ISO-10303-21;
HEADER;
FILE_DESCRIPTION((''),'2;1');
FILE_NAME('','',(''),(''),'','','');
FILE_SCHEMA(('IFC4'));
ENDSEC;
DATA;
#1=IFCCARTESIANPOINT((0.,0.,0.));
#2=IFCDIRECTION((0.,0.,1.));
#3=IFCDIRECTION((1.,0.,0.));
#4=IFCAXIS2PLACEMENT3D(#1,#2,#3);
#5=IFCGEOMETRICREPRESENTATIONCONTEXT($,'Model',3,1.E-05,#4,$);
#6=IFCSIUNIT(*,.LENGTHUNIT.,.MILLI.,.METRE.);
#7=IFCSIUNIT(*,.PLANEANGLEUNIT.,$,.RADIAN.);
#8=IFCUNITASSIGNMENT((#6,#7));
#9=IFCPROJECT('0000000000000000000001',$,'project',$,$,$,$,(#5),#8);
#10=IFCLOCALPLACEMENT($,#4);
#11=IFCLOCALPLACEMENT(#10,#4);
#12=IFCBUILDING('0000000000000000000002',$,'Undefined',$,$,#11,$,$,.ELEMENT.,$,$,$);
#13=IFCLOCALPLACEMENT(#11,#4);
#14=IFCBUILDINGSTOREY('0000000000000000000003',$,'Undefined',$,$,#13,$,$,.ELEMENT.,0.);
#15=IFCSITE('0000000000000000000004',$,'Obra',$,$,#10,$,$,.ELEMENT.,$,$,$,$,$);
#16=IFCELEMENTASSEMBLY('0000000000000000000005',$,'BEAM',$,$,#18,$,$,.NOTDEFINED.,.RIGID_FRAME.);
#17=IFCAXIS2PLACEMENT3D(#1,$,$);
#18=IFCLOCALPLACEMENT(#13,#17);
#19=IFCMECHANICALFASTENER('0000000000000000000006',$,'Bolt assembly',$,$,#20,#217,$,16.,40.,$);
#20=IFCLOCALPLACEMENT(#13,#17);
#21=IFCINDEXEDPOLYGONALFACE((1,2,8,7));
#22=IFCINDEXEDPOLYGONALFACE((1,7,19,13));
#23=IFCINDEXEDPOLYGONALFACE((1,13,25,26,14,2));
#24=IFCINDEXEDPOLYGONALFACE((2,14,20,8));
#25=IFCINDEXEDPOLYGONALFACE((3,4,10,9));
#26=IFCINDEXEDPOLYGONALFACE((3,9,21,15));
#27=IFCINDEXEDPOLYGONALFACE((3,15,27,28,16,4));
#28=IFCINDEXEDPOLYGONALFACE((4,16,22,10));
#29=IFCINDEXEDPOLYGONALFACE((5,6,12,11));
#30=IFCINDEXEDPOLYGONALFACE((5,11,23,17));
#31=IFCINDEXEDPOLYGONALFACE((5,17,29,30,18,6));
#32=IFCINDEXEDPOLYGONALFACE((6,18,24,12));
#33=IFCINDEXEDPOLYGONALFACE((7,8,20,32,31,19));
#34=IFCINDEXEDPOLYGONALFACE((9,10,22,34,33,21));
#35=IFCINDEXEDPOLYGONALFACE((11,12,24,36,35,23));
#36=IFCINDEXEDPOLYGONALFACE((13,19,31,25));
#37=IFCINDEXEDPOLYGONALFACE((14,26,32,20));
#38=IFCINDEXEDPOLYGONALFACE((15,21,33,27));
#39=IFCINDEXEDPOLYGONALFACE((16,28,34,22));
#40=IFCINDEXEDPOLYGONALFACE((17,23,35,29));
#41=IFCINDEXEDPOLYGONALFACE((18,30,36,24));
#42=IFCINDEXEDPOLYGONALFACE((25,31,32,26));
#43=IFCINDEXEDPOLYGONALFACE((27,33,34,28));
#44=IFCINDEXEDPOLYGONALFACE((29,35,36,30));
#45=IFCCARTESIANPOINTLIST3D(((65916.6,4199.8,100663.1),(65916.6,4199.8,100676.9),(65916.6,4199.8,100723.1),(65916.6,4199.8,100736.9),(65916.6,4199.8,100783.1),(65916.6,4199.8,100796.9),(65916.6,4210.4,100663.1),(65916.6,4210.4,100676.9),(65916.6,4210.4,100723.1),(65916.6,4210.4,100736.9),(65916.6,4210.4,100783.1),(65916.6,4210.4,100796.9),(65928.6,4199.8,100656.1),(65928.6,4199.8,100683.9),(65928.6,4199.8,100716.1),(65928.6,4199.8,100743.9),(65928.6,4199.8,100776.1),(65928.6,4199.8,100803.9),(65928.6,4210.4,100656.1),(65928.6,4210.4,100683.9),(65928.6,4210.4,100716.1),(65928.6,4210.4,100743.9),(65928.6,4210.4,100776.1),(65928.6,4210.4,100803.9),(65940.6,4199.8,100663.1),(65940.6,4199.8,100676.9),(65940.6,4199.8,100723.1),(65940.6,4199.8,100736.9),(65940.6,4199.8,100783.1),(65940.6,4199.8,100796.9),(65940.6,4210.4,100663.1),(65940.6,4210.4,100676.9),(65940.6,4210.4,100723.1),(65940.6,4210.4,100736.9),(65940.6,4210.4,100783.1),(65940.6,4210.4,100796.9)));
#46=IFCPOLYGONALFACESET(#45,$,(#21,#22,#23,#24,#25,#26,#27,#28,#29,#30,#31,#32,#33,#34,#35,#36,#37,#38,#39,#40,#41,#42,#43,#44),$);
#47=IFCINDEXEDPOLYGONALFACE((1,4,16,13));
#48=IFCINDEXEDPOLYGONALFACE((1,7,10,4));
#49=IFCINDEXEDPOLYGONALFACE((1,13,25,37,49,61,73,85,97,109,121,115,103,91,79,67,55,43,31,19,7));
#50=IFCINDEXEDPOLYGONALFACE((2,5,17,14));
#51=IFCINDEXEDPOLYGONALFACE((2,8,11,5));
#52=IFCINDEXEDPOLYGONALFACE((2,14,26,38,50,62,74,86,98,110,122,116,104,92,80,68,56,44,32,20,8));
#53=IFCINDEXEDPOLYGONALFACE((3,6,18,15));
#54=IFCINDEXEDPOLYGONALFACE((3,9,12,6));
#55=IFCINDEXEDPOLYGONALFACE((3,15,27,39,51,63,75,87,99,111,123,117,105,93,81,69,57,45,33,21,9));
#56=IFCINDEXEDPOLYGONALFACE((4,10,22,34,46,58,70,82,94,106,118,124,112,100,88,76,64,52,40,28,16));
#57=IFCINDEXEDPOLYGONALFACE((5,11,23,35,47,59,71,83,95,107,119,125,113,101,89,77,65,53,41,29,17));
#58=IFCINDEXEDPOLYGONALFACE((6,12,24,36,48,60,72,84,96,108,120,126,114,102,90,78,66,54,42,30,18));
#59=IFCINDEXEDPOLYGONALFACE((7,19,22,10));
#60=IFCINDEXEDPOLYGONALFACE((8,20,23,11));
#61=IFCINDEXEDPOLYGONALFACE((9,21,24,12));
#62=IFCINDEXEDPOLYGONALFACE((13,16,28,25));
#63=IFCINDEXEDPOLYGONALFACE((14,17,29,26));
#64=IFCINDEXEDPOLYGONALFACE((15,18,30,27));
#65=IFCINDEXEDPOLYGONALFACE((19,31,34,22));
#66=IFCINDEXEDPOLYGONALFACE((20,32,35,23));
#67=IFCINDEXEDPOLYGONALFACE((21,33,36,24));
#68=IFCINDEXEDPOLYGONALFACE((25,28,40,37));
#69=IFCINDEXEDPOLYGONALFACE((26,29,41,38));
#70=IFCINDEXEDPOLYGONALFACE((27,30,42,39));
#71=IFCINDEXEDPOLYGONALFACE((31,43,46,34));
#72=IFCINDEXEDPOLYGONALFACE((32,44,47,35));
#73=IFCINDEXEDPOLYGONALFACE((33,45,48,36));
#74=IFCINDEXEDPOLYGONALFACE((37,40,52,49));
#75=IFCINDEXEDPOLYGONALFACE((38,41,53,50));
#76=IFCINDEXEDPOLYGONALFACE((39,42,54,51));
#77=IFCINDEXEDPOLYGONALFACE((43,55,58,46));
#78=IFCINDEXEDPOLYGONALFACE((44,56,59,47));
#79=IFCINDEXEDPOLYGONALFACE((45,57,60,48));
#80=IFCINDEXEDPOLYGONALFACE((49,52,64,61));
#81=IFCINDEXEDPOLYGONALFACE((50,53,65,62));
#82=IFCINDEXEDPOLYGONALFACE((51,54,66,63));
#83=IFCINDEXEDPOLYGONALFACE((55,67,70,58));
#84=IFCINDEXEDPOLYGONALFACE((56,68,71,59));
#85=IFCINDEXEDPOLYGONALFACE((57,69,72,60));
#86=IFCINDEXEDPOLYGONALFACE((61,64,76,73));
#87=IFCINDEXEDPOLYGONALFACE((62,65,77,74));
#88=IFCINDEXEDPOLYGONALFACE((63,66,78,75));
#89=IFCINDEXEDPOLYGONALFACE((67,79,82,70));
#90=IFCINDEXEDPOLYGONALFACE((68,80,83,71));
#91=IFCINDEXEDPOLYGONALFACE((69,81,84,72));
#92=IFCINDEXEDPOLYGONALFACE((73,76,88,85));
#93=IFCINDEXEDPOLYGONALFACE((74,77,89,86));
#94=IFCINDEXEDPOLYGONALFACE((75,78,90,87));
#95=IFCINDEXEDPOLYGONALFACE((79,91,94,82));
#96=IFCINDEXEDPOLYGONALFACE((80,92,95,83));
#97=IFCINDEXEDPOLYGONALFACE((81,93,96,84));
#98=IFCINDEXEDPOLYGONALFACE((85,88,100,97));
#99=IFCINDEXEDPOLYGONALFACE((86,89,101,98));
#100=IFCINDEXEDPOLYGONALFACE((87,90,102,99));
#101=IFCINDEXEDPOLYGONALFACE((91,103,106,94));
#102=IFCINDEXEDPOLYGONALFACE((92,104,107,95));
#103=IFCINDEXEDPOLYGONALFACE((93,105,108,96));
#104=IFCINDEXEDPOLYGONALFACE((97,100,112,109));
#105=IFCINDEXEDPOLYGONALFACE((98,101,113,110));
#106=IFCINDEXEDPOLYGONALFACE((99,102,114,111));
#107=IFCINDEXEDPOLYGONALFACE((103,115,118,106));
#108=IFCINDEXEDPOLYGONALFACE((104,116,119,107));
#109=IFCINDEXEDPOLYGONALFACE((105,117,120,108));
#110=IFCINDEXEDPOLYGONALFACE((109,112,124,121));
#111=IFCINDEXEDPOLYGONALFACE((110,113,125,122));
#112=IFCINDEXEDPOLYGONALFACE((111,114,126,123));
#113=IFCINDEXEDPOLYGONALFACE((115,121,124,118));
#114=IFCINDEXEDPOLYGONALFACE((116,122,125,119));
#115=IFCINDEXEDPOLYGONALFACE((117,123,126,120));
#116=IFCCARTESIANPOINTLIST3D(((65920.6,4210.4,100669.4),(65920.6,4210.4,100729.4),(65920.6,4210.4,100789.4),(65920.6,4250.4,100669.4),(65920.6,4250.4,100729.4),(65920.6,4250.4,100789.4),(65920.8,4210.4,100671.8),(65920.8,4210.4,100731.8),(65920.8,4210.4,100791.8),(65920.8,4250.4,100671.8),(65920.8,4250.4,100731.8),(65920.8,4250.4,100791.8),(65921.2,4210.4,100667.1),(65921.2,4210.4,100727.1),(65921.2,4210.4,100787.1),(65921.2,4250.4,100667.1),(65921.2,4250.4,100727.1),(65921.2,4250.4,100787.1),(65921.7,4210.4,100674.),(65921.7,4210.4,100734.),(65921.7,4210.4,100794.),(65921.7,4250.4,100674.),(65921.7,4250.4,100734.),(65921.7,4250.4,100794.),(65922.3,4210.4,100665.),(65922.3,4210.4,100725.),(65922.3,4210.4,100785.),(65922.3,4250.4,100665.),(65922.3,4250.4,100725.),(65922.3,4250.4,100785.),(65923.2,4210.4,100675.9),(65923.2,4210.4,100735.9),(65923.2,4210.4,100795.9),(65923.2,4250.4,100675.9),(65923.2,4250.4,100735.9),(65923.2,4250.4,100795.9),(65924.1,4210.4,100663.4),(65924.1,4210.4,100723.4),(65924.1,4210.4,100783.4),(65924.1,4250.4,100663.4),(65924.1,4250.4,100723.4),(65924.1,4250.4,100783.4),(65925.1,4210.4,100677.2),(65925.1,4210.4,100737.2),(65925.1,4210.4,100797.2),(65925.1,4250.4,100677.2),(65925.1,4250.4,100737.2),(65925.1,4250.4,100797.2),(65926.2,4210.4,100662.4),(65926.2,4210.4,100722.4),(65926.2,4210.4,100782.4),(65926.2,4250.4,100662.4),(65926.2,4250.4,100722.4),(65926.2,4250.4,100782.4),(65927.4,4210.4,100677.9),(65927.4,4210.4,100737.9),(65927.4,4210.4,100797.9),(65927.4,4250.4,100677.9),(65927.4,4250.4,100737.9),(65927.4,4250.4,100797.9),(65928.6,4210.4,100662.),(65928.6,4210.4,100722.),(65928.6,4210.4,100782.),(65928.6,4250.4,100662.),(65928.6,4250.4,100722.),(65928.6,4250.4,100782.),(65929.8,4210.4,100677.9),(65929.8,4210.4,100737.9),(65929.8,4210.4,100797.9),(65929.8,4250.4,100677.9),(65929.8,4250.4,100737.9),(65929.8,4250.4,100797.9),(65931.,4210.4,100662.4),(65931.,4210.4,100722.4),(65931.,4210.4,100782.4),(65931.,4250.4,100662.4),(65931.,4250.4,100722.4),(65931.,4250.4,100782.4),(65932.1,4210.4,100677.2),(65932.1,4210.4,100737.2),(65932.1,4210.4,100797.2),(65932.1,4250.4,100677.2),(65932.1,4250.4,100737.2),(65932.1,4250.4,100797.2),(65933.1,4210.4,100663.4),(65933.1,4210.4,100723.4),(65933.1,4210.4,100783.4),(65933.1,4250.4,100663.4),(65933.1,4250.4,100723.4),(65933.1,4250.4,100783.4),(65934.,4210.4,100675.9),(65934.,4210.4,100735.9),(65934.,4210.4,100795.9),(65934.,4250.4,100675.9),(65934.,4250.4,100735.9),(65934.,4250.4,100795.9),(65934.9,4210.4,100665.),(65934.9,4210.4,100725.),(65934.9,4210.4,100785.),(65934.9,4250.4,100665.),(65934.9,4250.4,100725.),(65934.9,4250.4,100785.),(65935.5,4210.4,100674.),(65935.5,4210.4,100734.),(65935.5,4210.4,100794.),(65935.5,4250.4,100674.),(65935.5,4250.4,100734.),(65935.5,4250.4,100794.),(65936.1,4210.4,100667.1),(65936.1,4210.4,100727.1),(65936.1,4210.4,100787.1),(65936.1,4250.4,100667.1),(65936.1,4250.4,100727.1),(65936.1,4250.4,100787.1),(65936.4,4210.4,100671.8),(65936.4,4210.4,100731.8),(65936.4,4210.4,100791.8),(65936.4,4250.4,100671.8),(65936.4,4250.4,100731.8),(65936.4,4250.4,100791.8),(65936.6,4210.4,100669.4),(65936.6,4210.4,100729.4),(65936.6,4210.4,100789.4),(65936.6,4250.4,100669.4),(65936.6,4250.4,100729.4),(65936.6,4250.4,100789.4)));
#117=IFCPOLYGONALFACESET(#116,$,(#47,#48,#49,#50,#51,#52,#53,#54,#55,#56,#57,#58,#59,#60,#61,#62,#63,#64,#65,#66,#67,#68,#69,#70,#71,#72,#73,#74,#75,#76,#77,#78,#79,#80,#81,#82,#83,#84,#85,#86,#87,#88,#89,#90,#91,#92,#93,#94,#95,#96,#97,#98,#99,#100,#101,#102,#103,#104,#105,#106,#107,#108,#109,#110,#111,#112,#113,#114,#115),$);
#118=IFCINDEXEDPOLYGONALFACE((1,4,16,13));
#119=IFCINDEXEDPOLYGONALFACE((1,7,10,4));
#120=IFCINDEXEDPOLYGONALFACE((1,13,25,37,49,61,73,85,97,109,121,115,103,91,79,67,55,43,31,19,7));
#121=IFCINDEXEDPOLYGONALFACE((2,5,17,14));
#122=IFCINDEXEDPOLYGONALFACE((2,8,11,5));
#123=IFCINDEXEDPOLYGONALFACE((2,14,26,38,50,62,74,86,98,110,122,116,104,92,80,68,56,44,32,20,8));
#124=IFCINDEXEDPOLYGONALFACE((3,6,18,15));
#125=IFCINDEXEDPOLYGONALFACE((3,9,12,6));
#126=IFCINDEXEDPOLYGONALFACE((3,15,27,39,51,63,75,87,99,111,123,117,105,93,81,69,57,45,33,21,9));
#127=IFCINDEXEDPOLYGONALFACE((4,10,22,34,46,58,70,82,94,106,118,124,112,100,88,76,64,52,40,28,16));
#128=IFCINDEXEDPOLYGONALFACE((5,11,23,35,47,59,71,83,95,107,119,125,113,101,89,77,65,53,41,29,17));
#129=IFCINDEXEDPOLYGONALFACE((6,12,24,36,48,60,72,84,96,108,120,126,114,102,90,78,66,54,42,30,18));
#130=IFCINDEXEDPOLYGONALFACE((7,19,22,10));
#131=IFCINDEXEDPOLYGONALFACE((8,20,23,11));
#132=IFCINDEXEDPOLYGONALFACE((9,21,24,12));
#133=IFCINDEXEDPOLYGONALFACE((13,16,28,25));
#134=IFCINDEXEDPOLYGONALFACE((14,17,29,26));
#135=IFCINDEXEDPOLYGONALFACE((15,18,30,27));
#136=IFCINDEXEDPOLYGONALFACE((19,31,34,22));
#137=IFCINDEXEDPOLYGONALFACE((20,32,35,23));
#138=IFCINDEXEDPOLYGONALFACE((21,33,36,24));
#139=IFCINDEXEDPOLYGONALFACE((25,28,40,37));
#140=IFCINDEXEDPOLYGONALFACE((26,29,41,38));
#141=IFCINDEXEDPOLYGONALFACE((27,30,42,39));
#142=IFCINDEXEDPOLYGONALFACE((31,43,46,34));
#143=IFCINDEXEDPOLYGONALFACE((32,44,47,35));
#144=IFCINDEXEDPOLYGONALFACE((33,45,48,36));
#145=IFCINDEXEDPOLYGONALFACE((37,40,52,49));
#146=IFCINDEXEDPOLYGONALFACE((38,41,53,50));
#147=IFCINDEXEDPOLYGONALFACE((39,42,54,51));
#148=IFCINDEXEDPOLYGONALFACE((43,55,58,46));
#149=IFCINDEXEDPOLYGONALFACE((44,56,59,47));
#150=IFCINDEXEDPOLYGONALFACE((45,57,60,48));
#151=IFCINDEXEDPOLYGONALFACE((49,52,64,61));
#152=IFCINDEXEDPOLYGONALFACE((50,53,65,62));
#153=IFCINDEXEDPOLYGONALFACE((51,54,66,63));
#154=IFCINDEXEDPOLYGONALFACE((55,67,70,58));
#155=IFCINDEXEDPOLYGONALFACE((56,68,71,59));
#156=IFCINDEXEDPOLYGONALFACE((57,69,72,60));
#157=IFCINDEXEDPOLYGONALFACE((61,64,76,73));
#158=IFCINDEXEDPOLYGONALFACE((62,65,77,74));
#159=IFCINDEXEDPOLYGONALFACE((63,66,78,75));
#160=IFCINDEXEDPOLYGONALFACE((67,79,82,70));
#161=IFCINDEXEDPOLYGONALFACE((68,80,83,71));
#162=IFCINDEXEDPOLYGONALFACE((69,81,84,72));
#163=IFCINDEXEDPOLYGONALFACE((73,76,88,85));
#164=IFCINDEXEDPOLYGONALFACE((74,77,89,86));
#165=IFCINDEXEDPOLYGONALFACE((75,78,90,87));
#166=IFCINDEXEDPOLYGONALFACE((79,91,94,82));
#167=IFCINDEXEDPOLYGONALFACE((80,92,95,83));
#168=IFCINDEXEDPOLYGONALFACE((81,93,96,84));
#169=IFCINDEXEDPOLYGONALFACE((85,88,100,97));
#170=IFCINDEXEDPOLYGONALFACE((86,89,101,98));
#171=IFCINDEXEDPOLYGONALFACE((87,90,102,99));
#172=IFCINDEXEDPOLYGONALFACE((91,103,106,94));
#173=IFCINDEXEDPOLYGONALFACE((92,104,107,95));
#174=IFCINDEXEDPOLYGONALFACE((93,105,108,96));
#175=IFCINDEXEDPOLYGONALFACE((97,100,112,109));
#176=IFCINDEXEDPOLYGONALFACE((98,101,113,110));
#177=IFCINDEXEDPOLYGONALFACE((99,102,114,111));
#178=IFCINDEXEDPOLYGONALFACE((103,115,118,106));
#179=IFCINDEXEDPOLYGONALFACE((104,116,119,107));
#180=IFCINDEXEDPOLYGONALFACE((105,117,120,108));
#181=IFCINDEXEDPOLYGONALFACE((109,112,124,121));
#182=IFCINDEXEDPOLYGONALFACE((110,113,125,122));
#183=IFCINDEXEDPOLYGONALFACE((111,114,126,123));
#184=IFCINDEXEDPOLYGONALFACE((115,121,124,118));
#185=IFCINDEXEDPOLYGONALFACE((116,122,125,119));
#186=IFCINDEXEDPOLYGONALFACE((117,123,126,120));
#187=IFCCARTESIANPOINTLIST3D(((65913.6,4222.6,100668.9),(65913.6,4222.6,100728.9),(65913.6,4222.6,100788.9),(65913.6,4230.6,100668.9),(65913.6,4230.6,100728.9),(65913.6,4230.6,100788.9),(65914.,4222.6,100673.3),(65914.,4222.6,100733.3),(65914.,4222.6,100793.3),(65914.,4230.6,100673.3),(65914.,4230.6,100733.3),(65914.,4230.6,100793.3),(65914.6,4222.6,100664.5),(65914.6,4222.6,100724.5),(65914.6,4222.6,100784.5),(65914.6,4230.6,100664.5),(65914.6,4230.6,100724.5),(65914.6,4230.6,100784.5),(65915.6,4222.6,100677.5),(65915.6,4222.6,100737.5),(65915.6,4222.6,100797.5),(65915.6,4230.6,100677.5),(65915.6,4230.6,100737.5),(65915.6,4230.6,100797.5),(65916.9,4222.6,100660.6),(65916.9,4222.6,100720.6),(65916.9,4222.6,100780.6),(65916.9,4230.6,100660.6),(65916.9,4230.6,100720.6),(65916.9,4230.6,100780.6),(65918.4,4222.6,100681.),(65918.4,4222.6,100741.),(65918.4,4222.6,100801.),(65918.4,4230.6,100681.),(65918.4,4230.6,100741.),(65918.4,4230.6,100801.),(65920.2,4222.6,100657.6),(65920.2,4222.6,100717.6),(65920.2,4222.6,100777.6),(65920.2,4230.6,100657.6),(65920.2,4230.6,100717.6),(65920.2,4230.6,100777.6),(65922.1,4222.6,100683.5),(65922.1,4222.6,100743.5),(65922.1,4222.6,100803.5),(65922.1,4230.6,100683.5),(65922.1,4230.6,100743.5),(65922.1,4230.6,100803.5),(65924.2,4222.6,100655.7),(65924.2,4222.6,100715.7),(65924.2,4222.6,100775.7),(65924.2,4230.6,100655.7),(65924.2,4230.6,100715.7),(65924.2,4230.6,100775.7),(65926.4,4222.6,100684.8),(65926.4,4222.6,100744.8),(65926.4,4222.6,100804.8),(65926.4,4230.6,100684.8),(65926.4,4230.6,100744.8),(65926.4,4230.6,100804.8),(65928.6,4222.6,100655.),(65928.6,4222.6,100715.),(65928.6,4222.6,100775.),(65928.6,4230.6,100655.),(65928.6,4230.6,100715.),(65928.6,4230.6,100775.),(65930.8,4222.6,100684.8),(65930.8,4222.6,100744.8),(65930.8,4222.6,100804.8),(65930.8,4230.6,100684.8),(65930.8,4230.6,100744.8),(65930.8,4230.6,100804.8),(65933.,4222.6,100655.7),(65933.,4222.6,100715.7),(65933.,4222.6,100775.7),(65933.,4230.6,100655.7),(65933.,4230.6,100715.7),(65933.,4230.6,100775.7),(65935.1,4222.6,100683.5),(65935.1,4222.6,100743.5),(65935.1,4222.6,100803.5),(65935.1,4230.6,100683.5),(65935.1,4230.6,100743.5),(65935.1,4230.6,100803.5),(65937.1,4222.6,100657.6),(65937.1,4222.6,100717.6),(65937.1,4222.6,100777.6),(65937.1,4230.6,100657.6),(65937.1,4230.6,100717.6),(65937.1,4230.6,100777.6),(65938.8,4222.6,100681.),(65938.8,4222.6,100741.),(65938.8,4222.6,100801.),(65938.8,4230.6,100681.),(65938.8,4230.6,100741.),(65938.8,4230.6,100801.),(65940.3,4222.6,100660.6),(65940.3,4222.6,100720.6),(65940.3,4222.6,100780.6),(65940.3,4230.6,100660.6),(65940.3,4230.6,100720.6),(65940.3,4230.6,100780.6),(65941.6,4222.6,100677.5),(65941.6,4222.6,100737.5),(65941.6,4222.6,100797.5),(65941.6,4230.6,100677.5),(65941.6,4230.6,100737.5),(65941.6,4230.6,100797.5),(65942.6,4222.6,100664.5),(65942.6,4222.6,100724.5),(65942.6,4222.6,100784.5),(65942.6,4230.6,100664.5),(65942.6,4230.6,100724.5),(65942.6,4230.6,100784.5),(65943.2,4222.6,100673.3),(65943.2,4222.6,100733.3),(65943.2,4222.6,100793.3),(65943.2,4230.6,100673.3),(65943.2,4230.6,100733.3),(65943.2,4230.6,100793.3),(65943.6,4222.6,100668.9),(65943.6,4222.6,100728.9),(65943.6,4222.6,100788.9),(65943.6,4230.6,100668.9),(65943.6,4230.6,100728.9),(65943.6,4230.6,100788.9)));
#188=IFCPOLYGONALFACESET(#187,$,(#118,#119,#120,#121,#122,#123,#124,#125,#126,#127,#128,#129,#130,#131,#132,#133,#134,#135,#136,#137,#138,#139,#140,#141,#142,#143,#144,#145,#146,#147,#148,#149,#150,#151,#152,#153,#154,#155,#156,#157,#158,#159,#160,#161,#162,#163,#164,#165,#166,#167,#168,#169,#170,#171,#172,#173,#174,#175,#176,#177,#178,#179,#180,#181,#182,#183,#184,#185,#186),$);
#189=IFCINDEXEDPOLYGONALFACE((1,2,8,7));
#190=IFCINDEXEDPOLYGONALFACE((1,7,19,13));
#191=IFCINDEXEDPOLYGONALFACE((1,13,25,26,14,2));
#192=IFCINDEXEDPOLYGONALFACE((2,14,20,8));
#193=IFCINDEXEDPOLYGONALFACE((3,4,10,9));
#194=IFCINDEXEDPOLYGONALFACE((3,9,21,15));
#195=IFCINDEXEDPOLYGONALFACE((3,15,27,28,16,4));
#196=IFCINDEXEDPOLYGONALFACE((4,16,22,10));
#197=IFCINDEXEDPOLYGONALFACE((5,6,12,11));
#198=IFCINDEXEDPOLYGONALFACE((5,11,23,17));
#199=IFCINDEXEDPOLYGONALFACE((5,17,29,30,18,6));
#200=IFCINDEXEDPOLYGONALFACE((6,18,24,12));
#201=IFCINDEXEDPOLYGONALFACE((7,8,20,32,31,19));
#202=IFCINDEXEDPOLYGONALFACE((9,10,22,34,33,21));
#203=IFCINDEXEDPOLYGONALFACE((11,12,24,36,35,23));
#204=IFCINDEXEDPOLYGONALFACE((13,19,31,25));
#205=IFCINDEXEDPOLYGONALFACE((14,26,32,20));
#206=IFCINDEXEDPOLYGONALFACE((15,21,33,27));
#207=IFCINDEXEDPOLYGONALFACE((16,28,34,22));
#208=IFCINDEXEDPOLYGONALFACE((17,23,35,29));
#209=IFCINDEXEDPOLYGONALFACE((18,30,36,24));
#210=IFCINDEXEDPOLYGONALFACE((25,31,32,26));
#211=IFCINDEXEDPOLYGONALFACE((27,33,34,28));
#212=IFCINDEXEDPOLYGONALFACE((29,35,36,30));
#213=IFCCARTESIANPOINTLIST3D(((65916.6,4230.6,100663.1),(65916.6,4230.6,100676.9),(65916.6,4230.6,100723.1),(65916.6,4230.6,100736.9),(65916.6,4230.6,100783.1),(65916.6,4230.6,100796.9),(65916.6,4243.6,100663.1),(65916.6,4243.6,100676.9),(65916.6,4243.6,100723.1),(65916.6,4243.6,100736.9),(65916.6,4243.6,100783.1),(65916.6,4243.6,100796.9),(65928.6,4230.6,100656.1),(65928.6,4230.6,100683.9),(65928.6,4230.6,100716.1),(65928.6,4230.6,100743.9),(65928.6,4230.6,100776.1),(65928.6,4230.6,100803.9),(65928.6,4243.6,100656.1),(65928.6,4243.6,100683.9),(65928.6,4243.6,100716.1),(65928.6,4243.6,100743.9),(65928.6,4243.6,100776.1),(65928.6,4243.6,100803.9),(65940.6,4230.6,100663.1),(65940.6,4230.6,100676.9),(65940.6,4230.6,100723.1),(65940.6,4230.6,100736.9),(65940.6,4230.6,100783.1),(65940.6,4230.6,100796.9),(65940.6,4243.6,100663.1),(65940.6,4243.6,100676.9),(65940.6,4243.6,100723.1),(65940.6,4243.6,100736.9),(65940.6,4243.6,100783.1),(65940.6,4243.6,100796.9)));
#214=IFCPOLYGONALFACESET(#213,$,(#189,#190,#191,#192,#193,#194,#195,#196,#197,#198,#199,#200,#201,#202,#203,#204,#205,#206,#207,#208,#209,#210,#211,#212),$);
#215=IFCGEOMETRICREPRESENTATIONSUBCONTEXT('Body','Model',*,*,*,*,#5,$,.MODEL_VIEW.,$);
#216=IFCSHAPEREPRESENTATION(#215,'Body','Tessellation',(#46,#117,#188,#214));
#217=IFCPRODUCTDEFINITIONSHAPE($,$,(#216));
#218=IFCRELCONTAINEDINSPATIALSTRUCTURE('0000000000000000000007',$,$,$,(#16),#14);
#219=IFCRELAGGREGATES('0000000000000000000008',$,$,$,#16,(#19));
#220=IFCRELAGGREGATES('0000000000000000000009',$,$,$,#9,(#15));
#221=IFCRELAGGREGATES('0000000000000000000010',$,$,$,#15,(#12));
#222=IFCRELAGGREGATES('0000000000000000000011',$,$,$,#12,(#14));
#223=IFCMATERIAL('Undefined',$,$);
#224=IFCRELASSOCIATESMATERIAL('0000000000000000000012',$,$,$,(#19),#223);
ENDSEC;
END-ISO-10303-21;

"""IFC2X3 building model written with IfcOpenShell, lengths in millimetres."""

from ifc_helpers import new_model, si_unit, frame, origin_with_axes, origin_2d_with_axis, place, context, subcontext, project, spatial, polyline, circle, outline, extrude, source, transform, mapped, material, element, aggregate, save


model = new_model("IFC2X3")

# Units and contexts
model_context = context("Model", 3, precision=1e-05, world=origin_with_axes())
body_context = subcontext(model_context, "Body", "Model", "MODEL_VIEW")
ifc_project = project(units=[si_unit("LENGTHUNIT", "METRE", prefix="MILLI"), si_unit("PLANEANGLEUNIT", "RADIAN")], contexts=[model_context])

# Site, building, storey
site_placement = place(None, origin_with_axes())
site = spatial("IfcSite", under=ifc_project, at=site_placement, Name="Obra", CompositionType="ELEMENT")
building_placement = place(site_placement, origin_with_axes())
building = spatial("IfcBuilding", under=site, at=building_placement, Name="Undefined", CompositionType="ELEMENT")
storey_placement = place(building_placement, origin_with_axes())
storey = spatial("IfcBuildingStorey", under=building, at=storey_placement, Name="Undefined", CompositionType="ELEMENT", Elevation=0.0)

# Shared definitions
ifc_material_1 = material(Name="Undefined")

# Shared definitions
shared_shape_1 = source(origin_with_axes(), body_context, "Body", "SweptSolid", [
    extrude(outline(polyline([(13.9, 0.0), (6.9, 12.0), (-6.9, 12.0), (-13.9, 0.0), (-6.9, -12.0), (6.9, -12.0), (13.9, 0.0)])), frame((0.0, -19.7, 0.0), z_axis=(0.0, 1.0, 0.0), x_axis=(1.0, 0.0, 0.0)), (0.0, 0.0, 1.0), 10.6),
    extrude(circle(Radius=8.0, at=origin_2d_with_axis()), frame((0.0, -9.1, 0.0), z_axis=(0.0, 1.0, 0.0), x_axis=(1.0, 0.0, 0.0)), (0.0, 0.0, 1.0), 40.0),
    extrude(circle(Radius=15.0, at=origin_2d_with_axis()), frame((0.0, 3.1, 0.0), z_axis=(0.0, 1.0, 0.0), x_axis=(1.0, 0.0, 0.0)), (0.0, 0.0, 1.0), 8.0),
    extrude(outline(polyline([(13.9, 0.0), (6.9, 12.0), (-6.9, 12.0), (-13.9, 0.0), (-6.9, -12.0), (6.9, -12.0), (13.9, 0.0)])), frame((0.0, 11.1, 0.0), z_axis=(0.0, 1.0, 0.0), x_axis=(1.0, 0.0, 0.0)), (0.0, 0.0, 1.0), 13.0),
])

# Element assembly, mechanical fastener
assembly_1_placement = place(storey_placement, origin_with_axes())
assembly_1 = element("IfcElementAssembly", 1, at=assembly_1_placement, inside=storey, Name="BEAM", AssemblyPlace="NOTDEFINED", PredefinedType="RIGID_FRAME")
mechanical_fastener_1_placement = place(assembly_1_placement, frame((65878.6, 4219.5, 100850.0), z_axis=(1.0, 0.0, 0.0), x_axis=(0.0, 0.0, -1.0)))
mechanical_fastener_1 = element("IfcMechanicalFastener", 2, at=mechanical_fastener_1_placement, material=ifc_material_1, Name="Bolt assembly", NominalDiameter=16.0, NominalLength=40.0, context=body_context, shape_type="MappedRepresentation", body=[
    mapped(shared_shape_1, transform((60.0, 0.0, 50.0))),
    mapped(shared_shape_1, transform((120.0, 0.0, 50.0))),
    mapped(shared_shape_1, transform((180.0, 0.0, 50.0))),
])
aggregate(assembly_1, [mechanical_fastener_1])

save(model, "model.ifc")
